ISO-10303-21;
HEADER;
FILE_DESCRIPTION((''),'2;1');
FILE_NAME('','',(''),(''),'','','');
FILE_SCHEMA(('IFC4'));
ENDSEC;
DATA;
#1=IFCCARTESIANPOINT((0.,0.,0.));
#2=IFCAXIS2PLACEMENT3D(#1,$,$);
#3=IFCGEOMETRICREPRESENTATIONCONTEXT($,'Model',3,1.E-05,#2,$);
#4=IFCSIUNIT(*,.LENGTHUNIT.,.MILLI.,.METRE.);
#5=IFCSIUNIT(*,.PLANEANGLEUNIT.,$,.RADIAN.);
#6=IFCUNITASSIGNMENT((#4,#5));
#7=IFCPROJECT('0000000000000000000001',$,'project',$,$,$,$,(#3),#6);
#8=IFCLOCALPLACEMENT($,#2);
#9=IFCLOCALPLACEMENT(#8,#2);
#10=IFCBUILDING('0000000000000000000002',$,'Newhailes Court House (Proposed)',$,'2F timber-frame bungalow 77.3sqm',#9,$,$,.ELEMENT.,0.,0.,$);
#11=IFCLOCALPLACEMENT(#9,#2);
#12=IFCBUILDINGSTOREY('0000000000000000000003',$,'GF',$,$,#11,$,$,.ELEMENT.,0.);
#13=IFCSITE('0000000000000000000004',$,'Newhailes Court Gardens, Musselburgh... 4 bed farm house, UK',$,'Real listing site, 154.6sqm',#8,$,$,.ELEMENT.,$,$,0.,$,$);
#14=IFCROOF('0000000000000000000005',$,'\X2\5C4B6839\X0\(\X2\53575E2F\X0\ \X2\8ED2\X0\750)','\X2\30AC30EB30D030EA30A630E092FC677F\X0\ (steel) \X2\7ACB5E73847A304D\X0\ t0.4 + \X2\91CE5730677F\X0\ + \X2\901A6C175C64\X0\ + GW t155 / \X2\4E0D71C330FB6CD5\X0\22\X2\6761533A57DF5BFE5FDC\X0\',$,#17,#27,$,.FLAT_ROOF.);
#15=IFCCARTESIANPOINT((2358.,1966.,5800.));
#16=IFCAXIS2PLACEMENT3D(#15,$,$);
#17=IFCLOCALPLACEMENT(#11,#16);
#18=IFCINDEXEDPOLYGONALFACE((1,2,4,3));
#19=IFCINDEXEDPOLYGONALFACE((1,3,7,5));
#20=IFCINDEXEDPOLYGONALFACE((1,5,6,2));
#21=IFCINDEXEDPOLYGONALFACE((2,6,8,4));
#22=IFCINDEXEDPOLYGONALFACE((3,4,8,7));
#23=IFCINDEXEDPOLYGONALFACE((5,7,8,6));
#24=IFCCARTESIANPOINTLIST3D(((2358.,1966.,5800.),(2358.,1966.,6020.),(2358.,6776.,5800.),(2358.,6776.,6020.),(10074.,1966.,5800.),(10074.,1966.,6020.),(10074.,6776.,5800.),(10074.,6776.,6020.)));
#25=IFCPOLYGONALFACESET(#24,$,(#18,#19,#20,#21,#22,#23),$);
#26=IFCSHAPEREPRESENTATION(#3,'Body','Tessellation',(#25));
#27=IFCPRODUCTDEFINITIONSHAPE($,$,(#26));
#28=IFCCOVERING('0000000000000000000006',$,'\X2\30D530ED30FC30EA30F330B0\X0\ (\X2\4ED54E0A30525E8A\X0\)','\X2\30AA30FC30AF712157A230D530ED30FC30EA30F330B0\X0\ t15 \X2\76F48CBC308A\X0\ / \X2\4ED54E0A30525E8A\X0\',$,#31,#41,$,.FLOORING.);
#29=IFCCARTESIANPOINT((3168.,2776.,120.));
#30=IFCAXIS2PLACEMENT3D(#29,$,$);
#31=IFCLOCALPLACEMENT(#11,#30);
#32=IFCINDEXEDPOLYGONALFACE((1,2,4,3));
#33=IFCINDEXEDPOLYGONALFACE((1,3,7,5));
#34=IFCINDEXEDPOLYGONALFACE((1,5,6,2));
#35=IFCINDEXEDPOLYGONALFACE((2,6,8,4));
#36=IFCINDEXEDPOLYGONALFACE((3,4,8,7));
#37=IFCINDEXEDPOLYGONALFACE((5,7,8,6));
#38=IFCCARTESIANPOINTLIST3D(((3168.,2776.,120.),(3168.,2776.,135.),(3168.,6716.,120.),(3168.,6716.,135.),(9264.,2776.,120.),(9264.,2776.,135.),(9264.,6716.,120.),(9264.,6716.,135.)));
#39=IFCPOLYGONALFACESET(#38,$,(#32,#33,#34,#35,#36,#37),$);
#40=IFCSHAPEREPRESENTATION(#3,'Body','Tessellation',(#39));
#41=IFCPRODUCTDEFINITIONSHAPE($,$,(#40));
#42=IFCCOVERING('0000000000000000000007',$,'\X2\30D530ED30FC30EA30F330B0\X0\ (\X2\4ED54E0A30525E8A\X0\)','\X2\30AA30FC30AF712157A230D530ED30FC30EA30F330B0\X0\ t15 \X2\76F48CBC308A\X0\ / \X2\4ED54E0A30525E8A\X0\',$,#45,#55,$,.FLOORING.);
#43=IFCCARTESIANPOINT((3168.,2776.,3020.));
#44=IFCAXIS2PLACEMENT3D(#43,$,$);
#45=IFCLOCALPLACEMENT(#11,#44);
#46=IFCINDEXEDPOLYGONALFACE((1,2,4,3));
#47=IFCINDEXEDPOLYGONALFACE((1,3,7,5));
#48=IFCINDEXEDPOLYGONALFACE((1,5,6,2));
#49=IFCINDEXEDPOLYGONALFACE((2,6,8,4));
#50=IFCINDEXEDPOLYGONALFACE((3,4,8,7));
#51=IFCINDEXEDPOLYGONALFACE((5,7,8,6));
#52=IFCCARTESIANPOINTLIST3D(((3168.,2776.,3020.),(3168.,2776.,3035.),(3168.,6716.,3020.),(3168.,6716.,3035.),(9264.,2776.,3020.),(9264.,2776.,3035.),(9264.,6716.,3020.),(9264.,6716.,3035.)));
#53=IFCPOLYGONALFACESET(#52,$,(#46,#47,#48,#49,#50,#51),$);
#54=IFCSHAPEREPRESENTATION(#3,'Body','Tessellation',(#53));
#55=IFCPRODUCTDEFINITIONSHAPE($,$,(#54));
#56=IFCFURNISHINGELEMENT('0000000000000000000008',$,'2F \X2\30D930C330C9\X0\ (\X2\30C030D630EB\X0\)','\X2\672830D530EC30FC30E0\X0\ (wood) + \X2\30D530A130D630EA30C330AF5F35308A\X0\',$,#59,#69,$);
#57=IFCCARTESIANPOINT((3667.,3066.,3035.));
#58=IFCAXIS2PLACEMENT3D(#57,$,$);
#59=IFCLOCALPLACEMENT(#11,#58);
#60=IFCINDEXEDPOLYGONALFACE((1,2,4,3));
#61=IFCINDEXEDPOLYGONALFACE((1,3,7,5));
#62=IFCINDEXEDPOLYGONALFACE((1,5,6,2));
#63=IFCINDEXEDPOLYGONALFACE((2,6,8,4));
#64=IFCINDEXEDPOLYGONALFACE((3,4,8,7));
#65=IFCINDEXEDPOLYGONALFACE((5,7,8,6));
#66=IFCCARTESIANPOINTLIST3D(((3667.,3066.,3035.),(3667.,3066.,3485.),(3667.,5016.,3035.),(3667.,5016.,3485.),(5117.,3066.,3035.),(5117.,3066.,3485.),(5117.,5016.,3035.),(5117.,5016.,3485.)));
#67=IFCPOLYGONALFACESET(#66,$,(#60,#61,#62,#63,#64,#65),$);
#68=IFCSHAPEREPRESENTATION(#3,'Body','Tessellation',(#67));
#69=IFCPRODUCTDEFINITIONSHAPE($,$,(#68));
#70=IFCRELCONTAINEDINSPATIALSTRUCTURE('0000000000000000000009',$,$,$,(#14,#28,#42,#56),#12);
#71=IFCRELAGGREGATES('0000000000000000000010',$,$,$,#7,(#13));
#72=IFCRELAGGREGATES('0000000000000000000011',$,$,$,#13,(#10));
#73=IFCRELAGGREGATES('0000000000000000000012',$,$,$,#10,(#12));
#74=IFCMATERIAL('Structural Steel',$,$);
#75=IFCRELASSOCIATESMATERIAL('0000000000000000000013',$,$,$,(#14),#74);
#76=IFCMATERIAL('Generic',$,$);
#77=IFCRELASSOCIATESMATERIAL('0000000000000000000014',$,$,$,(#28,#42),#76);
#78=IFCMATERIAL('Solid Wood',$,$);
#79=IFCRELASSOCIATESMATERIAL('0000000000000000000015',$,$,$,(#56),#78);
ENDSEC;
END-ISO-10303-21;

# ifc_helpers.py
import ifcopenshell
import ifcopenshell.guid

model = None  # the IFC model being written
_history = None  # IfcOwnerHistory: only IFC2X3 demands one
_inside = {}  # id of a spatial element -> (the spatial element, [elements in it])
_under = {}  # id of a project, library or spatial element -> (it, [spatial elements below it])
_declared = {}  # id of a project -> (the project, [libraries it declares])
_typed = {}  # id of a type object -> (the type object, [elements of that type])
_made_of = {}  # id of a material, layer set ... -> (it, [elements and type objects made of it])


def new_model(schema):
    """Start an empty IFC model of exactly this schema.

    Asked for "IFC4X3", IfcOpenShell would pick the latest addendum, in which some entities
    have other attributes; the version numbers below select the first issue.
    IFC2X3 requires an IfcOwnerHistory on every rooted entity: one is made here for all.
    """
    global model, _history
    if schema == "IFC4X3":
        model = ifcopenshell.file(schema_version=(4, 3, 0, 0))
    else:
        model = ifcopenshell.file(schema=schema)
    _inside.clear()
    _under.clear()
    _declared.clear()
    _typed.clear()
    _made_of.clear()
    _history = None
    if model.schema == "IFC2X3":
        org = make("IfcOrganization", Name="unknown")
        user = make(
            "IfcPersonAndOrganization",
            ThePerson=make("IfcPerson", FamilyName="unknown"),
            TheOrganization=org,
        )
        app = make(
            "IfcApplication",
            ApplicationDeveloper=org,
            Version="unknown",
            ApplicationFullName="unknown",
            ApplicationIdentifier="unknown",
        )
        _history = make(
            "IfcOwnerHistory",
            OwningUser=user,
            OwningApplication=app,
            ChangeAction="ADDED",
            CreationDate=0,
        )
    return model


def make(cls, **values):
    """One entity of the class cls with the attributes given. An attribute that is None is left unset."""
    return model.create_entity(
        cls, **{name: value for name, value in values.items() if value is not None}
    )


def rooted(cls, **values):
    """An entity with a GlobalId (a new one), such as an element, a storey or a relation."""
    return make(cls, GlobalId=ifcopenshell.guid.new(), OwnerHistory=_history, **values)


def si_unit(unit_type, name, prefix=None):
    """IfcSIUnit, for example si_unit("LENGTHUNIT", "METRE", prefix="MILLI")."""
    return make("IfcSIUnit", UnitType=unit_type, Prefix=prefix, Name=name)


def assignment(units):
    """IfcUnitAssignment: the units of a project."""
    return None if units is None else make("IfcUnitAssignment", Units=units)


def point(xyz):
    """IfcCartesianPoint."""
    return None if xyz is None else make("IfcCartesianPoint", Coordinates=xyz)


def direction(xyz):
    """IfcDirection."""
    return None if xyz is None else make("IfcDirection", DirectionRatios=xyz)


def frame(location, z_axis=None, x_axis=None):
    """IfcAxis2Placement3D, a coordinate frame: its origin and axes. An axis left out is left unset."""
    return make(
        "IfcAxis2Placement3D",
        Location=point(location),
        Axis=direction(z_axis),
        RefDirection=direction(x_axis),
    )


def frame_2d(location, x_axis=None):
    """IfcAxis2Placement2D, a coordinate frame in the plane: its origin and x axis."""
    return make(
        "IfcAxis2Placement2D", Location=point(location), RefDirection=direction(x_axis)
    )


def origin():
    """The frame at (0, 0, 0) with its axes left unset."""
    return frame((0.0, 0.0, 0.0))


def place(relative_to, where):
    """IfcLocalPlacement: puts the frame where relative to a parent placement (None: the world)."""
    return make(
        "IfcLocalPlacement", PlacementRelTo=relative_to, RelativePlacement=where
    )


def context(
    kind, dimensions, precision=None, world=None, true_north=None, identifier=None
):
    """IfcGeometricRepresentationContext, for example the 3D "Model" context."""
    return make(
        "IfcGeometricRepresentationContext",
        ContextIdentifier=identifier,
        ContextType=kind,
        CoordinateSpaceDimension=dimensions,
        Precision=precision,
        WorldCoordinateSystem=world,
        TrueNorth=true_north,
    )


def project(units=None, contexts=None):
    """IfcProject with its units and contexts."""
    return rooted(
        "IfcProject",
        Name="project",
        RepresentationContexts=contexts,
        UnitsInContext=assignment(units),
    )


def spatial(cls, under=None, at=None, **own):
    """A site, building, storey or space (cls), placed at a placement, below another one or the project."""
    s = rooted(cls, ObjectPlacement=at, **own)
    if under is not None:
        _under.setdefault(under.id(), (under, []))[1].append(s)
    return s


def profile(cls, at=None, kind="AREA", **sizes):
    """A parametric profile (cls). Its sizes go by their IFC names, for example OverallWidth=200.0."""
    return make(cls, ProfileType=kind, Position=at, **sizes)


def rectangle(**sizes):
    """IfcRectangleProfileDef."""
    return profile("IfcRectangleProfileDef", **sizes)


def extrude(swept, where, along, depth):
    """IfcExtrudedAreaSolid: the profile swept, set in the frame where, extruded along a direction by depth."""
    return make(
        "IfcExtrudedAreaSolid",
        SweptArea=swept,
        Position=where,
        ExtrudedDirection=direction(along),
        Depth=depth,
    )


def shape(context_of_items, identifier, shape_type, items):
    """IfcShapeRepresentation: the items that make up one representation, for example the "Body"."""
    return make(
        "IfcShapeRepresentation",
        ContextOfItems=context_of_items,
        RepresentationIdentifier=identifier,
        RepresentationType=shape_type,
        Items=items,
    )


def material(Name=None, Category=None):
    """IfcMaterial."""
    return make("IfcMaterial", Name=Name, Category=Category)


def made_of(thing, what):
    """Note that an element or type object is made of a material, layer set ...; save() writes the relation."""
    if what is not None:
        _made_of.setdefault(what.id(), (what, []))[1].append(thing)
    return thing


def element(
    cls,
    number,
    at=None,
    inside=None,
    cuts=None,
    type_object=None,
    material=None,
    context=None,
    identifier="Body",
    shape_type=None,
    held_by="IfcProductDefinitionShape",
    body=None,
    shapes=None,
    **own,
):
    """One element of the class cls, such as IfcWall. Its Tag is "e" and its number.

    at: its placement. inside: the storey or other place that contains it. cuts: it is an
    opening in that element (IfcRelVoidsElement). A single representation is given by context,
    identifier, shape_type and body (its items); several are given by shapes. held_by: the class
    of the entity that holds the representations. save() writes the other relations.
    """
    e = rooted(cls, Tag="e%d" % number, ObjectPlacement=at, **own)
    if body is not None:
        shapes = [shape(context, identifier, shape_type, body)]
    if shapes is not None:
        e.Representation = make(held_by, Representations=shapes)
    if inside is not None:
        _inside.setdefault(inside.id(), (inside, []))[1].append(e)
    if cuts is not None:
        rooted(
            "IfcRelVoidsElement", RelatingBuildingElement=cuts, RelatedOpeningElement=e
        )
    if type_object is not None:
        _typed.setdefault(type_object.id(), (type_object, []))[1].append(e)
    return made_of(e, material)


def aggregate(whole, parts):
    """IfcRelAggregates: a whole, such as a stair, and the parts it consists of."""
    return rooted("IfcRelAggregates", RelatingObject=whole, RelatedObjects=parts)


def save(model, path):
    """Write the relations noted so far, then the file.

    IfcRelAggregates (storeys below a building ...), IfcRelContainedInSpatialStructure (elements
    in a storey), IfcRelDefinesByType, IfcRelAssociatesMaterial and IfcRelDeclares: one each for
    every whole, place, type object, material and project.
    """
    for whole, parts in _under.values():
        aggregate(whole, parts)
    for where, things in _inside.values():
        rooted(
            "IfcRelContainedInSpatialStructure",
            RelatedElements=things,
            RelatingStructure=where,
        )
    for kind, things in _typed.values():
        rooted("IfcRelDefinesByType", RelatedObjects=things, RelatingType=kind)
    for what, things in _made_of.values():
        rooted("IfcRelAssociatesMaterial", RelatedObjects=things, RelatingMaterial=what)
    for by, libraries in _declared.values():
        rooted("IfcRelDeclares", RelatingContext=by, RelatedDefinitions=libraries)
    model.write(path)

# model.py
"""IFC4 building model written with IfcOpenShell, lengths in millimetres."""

from ifc_helpers import new_model, si_unit, frame, frame_2d, origin, place, context, project, spatial, rectangle, extrude, material, element, save


model = new_model("IFC4")

# Units and contexts
model_context = context("Model", 3, precision=1e-05, world=origin())
ifc_project = project(units=[si_unit("LENGTHUNIT", "METRE", prefix="MILLI"), si_unit("PLANEANGLEUNIT", "RADIAN")], contexts=[model_context])

# Site, building, storey
site_placement = place(None, origin())
site = spatial("IfcSite", under=ifc_project, at=site_placement, Name="Newhailes Court Gardens, Musselburgh... 4 bed farm house, UK", ObjectType="Real listing site, 154.6sqm", CompositionType="ELEMENT", RefElevation=0.0)
building_placement = place(site_placement, origin())
building = spatial("IfcBuilding", under=site, at=building_placement, Name="Newhailes Court House (Proposed)", ObjectType="2F timber-frame bungalow 77.3sqm", CompositionType="ELEMENT", ElevationOfRefHeight=0.0, ElevationOfTerrain=0.0)
storey_placement = place(building_placement, origin())
storey = spatial("IfcBuildingStorey", under=building, at=storey_placement, Name="GF", CompositionType="ELEMENT", Elevation=0.0)

# Shared definitions
ifc_material_1 = material(Name="Solid Wood")

# Roof
ifc_material_2 = material(Name="Structural Steel")
for number, where, name in (
    (1, (2358.0, 1966.0, 5800.0), "屋根(南帯 軒750)"),
):
    element("IfcRoof", number, at=place(storey_placement, frame(where)), inside=storey, material=ifc_material_2, Name=name, Description="ガルバリウム鋼板 (steel) 立平葺き t0.4 + 野地板 + 通気層 + GW t155 / 不燃・法22条区域対応", PredefinedType="FLAT_ROOF", context=model_context, shape_type="SweptSolid", body=[
        extrude(rectangle(XDim=7716.0, YDim=4810.0, at=frame_2d((3858.0, 2405.0))), frame((2358.0, 1966.0, 5800.0)), (0.0, 0.0, 1.0), 220.0),
    ])

# Coverings
ifc_material_3 = material(Name="Generic")
covering_1_placement = place(storey_placement, frame((3168.0, 2776.0, 120.0)))
element("IfcCovering", 2, at=covering_1_placement, inside=storey, material=ifc_material_3, Name="フローリング (仕上げ床)", Description="オーク無垢フローリング t15 直貼り / 仕上げ床", PredefinedType="FLOORING", context=model_context, shape_type="SweptSolid", body=[
    extrude(rectangle(XDim=6096.0, YDim=3940.0, at=frame_2d((3048.0, 1970.0))), frame((3168.0, 2776.0, 120.0)), (0.0, 0.0, 1.0), 15.0),
])
covering_2_placement = place(storey_placement, frame((3168.0, 2776.0, 3020.0)))
element("IfcCovering", 3, at=covering_2_placement, inside=storey, material=ifc_material_3, Name="フローリング (仕上げ床)", Description="オーク無垢フローリング t15 直貼り / 仕上げ床", PredefinedType="FLOORING", context=model_context, shape_type="SweptSolid", body=[
    extrude(rectangle(XDim=6096.0, YDim=3940.0, at=frame_2d((3048.0, 1970.0))), frame((3168.0, 2776.0, 3020.0)), (0.0, 0.0, 1.0), 15.0),
])

# Furnishing element
furnishing_placement = place(storey_placement, frame((3667.0, 3066.0, 3035.0)))
element("IfcFurnishingElement", 4, at=furnishing_placement, inside=storey, material=ifc_material_1, Name="2F ベッド (ダブル)", Description="木フレーム (wood) + ファブリック張り", context=model_context, shape_type="SweptSolid", body=[
    extrude(rectangle(XDim=1450.0, YDim=1950.0, at=frame_2d((725.0, 975.0))), frame((3667.0, 3066.0, 3035.0)), (0.0, 0.0, 1.0), 450.0),
])

save(model, "model.ifc")
